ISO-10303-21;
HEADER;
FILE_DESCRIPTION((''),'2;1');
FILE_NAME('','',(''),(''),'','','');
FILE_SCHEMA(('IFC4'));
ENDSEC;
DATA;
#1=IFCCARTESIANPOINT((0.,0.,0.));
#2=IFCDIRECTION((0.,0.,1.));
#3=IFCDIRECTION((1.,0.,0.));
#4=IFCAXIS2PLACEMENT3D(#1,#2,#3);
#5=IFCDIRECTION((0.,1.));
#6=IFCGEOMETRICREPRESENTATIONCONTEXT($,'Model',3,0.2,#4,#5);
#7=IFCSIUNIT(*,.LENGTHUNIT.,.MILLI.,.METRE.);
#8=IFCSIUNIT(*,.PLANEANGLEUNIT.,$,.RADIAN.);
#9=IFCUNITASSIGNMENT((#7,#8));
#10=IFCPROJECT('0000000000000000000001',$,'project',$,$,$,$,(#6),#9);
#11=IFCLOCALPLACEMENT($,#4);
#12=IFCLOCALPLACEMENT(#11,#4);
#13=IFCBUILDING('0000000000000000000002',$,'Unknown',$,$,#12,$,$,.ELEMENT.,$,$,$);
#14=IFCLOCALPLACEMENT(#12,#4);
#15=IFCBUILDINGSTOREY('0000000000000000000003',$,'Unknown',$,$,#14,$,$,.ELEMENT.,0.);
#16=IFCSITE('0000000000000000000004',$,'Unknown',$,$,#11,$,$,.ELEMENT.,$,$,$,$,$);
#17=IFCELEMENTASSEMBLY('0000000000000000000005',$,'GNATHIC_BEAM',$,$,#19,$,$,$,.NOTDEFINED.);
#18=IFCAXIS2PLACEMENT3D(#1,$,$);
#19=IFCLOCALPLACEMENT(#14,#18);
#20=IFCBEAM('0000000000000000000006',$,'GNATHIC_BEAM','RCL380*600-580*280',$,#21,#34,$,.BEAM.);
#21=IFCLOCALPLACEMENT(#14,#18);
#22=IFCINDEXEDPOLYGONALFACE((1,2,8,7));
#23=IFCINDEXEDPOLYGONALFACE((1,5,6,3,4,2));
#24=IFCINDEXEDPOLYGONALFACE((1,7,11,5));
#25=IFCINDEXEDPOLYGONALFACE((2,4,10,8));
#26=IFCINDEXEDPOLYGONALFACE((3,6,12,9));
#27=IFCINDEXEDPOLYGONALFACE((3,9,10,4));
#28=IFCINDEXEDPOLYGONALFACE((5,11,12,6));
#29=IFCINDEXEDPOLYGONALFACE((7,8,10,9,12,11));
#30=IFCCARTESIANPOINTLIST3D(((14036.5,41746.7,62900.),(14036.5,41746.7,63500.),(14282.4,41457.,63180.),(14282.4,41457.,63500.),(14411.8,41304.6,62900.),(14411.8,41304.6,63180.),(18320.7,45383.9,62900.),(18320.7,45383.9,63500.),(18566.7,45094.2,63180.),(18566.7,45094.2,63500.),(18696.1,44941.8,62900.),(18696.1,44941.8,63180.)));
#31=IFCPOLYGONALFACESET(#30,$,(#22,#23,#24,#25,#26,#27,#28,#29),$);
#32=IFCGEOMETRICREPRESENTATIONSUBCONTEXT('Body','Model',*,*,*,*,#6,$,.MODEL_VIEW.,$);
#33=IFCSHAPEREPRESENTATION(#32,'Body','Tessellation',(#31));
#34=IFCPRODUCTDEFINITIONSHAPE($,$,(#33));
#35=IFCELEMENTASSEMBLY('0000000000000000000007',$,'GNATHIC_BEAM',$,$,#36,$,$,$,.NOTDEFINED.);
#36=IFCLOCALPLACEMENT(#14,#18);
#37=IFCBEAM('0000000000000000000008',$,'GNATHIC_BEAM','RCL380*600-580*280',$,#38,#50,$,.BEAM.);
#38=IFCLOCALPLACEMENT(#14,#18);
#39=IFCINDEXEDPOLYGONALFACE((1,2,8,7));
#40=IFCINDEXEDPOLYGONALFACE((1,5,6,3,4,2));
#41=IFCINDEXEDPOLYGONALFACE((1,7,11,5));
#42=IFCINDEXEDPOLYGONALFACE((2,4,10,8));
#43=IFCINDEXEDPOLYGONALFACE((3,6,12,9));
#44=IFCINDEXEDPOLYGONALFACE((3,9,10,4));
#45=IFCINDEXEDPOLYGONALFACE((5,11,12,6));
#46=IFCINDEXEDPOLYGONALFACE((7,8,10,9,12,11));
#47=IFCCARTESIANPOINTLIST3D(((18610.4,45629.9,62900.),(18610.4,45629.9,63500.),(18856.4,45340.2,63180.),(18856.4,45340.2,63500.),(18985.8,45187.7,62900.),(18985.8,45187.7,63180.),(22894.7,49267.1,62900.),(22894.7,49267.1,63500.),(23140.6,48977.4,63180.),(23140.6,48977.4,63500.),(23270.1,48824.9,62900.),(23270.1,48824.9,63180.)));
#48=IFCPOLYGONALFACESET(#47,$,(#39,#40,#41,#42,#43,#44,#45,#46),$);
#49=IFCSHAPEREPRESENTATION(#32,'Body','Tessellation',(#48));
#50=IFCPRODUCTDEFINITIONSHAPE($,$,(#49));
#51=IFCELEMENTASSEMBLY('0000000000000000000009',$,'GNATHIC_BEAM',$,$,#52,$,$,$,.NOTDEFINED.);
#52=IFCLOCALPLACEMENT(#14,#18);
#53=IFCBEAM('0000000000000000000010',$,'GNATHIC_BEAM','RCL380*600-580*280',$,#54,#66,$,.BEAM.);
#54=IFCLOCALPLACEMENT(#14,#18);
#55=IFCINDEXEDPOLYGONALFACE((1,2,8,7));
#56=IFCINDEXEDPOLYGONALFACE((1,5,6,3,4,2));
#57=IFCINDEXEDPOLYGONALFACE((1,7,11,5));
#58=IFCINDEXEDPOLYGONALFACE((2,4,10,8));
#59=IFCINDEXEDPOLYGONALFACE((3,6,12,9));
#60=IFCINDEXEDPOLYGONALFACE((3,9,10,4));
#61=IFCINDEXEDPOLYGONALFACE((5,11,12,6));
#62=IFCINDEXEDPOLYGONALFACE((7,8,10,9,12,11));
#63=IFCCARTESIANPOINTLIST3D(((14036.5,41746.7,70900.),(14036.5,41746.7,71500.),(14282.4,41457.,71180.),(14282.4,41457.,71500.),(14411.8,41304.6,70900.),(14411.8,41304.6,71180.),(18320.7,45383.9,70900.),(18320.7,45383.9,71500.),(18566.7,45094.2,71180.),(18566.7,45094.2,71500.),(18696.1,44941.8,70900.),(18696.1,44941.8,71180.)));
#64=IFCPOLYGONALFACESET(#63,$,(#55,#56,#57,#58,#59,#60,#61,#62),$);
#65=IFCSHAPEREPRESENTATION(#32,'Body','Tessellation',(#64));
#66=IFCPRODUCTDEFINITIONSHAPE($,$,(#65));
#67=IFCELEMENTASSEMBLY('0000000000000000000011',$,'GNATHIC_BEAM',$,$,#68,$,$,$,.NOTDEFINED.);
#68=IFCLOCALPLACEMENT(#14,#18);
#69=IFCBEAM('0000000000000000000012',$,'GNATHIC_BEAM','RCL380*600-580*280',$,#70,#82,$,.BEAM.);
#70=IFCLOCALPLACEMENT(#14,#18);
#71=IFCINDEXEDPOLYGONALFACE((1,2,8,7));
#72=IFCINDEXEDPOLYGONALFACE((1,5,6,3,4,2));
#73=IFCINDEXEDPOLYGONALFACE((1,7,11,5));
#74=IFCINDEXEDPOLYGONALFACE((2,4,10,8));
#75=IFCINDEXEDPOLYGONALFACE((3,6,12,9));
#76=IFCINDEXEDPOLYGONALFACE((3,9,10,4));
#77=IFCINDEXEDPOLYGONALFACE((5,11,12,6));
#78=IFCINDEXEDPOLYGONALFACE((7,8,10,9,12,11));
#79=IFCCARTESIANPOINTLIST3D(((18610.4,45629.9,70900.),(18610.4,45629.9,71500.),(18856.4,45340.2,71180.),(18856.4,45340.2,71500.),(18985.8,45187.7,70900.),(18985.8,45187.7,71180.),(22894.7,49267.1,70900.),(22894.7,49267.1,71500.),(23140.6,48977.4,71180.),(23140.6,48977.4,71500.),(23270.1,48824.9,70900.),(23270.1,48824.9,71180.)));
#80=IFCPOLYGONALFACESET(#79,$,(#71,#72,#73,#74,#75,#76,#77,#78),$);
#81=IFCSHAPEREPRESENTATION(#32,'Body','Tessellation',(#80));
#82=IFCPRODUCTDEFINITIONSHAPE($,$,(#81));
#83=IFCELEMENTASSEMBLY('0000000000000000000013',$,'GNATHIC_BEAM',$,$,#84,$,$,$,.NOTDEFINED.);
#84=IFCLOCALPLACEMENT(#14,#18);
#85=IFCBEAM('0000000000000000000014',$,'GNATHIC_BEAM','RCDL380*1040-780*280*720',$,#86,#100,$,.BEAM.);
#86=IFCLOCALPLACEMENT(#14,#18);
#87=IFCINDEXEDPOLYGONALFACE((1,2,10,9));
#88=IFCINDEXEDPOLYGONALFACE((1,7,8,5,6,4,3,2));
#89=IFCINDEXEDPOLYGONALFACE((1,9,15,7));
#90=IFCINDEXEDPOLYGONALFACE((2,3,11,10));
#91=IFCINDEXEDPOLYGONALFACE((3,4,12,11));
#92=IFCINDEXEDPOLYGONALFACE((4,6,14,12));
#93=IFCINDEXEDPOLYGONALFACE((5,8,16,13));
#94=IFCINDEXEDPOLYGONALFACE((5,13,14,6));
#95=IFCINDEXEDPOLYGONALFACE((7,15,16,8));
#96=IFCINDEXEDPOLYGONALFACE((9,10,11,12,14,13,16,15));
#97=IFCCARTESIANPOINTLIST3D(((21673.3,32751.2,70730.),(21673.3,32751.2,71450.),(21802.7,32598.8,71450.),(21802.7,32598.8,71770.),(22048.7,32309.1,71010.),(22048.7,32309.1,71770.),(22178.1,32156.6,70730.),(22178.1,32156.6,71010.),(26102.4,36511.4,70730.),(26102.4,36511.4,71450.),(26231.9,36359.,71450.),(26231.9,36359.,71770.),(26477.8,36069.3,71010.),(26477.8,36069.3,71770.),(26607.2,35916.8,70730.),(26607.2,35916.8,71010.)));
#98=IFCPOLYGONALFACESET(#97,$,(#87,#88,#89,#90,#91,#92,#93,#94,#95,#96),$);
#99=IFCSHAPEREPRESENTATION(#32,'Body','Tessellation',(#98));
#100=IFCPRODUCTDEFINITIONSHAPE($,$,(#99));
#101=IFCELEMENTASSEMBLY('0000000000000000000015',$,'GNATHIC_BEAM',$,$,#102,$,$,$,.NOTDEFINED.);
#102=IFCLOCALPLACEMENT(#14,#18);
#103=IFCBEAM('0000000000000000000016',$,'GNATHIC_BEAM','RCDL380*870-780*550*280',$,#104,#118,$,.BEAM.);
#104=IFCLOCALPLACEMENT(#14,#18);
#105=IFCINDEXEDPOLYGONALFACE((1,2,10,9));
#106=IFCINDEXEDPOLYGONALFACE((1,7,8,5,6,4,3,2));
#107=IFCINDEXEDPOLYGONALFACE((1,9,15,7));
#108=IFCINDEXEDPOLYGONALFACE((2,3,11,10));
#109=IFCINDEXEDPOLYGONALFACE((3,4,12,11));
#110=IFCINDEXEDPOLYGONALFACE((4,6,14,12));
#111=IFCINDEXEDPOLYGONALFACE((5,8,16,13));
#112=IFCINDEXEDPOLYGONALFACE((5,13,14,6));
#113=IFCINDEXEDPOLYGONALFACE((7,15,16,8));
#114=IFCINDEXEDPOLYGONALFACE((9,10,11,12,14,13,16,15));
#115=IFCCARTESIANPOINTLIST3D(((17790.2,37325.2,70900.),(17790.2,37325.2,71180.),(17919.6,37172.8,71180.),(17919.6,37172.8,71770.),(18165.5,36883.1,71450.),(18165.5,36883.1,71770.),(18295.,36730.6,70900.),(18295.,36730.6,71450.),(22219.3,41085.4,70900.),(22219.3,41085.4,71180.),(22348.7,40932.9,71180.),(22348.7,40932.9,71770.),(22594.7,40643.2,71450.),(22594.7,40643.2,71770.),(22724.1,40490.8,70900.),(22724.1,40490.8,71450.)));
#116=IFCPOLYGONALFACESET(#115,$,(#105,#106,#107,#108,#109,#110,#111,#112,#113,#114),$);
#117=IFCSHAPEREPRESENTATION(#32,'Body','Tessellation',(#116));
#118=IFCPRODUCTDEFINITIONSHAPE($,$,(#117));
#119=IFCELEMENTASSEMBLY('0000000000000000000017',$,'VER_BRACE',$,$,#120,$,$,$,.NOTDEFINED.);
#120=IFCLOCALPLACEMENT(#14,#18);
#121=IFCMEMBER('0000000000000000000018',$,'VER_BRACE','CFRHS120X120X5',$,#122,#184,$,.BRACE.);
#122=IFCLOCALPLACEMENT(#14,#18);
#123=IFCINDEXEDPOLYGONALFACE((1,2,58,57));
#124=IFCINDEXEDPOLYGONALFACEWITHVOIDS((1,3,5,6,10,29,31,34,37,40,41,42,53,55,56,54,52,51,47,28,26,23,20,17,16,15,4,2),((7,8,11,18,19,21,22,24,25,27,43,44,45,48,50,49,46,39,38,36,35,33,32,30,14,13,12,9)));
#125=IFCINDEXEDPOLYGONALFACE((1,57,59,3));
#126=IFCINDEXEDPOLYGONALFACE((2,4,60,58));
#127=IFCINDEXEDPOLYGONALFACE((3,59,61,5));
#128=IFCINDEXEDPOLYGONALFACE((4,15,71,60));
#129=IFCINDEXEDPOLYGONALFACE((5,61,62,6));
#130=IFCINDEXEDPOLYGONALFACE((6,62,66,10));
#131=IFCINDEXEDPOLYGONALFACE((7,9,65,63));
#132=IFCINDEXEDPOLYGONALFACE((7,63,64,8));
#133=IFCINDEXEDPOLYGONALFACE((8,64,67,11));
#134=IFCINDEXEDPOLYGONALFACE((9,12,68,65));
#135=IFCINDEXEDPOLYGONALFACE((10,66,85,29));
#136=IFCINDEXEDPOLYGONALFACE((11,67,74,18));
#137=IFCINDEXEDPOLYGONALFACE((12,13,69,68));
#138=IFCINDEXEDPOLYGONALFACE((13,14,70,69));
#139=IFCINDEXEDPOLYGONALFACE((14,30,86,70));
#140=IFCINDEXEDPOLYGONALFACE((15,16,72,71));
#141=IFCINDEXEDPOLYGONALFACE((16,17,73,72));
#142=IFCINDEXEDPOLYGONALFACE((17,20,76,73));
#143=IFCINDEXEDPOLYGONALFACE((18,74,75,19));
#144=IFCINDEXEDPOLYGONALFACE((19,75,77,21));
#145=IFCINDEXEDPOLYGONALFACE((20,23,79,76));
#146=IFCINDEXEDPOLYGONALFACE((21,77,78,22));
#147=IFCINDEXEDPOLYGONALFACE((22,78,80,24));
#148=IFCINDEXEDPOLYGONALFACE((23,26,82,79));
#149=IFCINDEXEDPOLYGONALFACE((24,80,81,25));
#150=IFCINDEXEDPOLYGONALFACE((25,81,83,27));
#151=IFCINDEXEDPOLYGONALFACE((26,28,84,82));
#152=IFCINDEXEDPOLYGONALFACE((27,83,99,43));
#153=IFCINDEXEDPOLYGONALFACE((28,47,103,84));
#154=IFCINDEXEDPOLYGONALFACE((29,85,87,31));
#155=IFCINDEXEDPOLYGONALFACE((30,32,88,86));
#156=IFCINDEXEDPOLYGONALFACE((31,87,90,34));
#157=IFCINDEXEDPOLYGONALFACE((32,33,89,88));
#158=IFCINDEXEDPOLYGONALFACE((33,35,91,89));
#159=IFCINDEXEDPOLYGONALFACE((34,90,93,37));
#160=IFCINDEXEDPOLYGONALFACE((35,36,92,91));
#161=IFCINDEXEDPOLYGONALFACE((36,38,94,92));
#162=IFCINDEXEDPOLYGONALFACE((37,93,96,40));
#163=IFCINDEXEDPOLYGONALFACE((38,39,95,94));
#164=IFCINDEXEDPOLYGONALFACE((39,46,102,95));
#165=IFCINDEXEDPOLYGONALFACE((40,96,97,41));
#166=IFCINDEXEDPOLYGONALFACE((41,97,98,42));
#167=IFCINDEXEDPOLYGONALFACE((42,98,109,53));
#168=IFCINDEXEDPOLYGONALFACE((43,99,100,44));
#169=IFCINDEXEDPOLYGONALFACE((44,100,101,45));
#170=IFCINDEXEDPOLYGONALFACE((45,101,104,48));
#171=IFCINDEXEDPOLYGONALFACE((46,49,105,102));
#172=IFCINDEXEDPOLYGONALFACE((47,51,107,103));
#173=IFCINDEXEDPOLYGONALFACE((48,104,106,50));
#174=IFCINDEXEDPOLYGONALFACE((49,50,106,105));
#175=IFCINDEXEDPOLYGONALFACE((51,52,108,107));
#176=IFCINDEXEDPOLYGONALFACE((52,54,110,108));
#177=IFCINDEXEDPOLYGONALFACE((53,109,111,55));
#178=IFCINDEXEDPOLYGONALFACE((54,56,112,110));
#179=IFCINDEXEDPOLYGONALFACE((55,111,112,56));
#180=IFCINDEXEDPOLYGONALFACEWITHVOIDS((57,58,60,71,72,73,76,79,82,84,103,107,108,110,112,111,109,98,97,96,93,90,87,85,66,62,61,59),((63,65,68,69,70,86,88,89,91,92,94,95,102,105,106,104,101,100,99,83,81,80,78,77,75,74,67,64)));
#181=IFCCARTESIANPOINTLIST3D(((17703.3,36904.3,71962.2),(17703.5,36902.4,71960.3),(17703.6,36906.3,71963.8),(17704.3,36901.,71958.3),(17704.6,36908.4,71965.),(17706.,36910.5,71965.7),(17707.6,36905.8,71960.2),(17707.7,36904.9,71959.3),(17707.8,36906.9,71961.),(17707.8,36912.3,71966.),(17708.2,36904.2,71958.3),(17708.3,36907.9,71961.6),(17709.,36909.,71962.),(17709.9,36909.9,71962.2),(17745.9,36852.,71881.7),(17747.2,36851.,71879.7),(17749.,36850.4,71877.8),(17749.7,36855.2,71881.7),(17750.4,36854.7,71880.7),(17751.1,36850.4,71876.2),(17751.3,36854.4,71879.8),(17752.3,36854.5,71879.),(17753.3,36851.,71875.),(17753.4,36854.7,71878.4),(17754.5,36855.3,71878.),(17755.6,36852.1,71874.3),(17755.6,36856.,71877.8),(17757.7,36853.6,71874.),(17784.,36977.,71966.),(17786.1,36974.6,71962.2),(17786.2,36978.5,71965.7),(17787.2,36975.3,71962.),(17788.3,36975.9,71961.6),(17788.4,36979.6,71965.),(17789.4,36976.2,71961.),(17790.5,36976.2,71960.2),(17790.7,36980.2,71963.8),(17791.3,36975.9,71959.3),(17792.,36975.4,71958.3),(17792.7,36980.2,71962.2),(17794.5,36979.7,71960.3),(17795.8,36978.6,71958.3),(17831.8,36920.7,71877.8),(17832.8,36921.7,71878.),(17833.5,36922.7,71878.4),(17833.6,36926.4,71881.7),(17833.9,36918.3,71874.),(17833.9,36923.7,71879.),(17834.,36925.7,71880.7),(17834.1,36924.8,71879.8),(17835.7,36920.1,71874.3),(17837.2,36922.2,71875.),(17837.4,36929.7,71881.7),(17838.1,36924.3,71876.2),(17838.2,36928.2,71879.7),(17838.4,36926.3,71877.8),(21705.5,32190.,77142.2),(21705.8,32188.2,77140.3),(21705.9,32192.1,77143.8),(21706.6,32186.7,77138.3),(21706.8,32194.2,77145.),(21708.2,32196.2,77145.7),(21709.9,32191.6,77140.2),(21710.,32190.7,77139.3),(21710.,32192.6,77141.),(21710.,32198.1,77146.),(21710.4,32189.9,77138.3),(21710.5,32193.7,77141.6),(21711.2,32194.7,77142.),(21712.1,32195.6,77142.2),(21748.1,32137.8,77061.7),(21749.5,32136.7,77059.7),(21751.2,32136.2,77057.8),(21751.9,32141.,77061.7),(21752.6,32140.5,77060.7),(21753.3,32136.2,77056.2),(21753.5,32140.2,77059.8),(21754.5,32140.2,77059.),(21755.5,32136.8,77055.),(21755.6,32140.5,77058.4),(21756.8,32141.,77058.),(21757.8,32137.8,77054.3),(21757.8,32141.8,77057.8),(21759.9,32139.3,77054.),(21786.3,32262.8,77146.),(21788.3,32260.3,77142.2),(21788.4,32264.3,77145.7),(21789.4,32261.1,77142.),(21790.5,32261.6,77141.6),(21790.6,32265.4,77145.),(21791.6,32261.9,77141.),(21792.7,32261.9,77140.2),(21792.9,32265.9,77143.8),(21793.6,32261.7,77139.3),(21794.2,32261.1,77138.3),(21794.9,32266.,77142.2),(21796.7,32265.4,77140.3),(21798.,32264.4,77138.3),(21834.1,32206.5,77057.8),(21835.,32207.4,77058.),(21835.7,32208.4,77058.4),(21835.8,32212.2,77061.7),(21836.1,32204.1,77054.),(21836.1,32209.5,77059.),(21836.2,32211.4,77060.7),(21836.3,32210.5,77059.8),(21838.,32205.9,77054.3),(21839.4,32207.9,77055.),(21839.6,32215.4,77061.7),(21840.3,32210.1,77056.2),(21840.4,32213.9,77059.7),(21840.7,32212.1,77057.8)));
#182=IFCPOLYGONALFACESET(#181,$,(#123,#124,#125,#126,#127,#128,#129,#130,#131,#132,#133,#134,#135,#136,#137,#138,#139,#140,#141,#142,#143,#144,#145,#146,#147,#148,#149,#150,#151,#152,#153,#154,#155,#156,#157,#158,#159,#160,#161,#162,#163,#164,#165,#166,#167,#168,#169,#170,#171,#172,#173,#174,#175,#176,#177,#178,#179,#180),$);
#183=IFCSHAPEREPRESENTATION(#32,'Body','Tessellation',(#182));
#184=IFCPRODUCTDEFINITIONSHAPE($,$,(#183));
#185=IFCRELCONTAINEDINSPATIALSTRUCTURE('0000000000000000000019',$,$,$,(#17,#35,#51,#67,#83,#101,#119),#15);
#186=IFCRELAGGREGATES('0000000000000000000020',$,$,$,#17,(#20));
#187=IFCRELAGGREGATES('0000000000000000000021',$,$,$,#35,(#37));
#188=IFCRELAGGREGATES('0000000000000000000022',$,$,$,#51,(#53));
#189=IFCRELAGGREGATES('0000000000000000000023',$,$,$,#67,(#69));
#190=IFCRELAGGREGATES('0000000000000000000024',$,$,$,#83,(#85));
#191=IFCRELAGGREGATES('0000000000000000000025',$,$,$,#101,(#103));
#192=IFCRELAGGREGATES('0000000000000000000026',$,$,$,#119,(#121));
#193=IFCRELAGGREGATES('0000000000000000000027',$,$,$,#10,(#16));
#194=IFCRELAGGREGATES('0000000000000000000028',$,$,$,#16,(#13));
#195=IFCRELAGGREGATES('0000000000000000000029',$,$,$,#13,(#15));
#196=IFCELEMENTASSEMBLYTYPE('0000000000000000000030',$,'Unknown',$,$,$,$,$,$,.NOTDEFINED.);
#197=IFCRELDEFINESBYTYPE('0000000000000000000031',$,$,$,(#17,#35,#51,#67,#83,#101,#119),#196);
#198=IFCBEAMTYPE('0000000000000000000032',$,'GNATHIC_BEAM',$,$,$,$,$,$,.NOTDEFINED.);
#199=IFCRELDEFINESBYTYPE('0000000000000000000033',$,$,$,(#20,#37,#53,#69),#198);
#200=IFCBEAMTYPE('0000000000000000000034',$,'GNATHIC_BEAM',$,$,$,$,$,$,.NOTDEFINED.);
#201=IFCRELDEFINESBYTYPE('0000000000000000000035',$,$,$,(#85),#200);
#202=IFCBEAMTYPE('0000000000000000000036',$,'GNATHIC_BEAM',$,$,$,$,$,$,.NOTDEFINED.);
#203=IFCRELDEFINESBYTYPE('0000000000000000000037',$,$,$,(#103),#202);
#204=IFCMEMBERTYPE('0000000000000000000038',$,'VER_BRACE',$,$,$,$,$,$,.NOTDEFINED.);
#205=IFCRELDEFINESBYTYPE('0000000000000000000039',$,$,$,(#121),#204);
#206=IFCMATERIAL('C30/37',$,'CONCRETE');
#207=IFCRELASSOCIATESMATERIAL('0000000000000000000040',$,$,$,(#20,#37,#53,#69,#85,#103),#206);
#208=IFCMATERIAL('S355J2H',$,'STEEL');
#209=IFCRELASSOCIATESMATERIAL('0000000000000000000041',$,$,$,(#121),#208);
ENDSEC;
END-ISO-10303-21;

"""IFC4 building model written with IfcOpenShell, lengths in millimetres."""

from ifc_helpers import new_model, si_unit, direction, frame, origin_with_axes, origin_2d_with_axis, place, context, subcontext, project, spatial, polyline, hollow_rectangle, outline, extrude, material, material_profile, profile_set, profile_usage, type_object, element, aggregate, save


model = new_model("IFC4")

# Units and contexts
model_context = context("Model", 3, precision=0.2, world=origin_with_axes(), true_north=direction((0.0, 1.0)))
body_context = subcontext(model_context, "Body", "Model", "MODEL_VIEW")
ifc_project = project(units=[si_unit("LENGTHUNIT", "METRE", prefix="MILLI"), si_unit("PLANEANGLEUNIT", "RADIAN")], contexts=[model_context])

# Site, building, storey
site_placement = place(None, origin_with_axes())
site = spatial("IfcSite", under=ifc_project, at=site_placement, Name="Unknown", CompositionType="ELEMENT")
building_placement = place(site_placement, origin_with_axes())
building = spatial("IfcBuilding", under=site, at=building_placement, Name="Unknown", CompositionType="ELEMENT")
storey_placement = place(building_placement, origin_with_axes())
storey = spatial("IfcBuildingStorey", under=building, at=storey_placement, Name="Unknown", CompositionType="ELEMENT", Elevation=0.0)

# Shared definitions
element_assembly_type = type_object("IfcElementAssemblyType", Name="Unknown", PredefinedType="NOTDEFINED")

# Element assemblies, beams
ifc_material_1 = material(Name="C30/37", Category="CONCRETE")
ifc_material_profile_1 = material_profile(ifc_material_1, outline(polyline([(-190.0, -300.0), (390.0, -300.0), (390.0, -20.0), (190.0, -20.0), (190.0, 300.0), (-190.0, 300.0), (-190.0, -300.0)])), Name="RCL380*600-580*280")
ifc_profile_set_1 = profile_set([ifc_material_profile_1])
ifc_profile_usage_1 = profile_usage(ifc_profile_set_1, cardinal=2)
beam_type_1 = type_object("IfcBeamType", Name="GNATHIC_BEAM")
assembly_1_placement = place(storey_placement, frame((14159.4, 41601.9, 63200.0), z_axis=(0.64719, -0.762329, 0.0), x_axis=(0.762329, 0.64719, 0.0)))
assembly_1 = element("IfcElementAssembly", 1, at=assembly_1_placement, inside=storey, type_object=element_assembly_type, Name="GNATHIC_BEAM", PredefinedType="NOTDEFINED")
beam_1_placement = place(assembly_1_placement, origin_with_axes())
beam_1 = element("IfcBeam", 2, at=beam_1_placement, type_object=beam_type_1, material=ifc_profile_usage_1, Name="GNATHIC_BEAM", Description="RCL380*600-580*280", PredefinedType="BEAM", context=body_context, shape_type="SolidModel", body=[
    extrude(outline(polyline([(-190.0, -300.0), (390.0, -300.0), (390.0, -20.0), (190.0, -20.0), (190.0, 300.0), (-190.0, 300.0), (-190.0, -300.0)])), frame((0.0, 0.0, 0.0), z_axis=(-1.0, 0.0, 0.0), x_axis=(0.0, 0.0, 1.0)), (0.0, 0.0, -1.0), 5620.0),
])
aggregate(assembly_1, [beam_1])
assembly_2_placement = place(storey_placement, frame((18733.4, 45485.0, 63200.0), z_axis=(0.64719, -0.762329, 0.0), x_axis=(0.762329, 0.64719, 0.0)))
assembly_2 = element("IfcElementAssembly", 3, at=assembly_2_placement, inside=storey, type_object=element_assembly_type, Name="GNATHIC_BEAM", PredefinedType="NOTDEFINED")
beam_2_placement = place(assembly_2_placement, origin_with_axes())
beam_2 = element("IfcBeam", 4, at=beam_2_placement, type_object=beam_type_1, material=ifc_profile_usage_1, Name="GNATHIC_BEAM", Description="RCL380*600-580*280", PredefinedType="BEAM", context=body_context, shape_type="SolidModel", body=[
    extrude(outline(polyline([(-190.0, -300.0), (390.0, -300.0), (390.0, -20.0), (190.0, -20.0), (190.0, 300.0), (-190.0, 300.0), (-190.0, -300.0)])), frame((0.0, 0.0, 0.0), z_axis=(-1.0, 0.0, 0.0), x_axis=(0.0, 0.0, 1.0)), (0.0, 0.0, -1.0), 5620.0),
])
aggregate(assembly_2, [beam_2])
assembly_3_placement = place(storey_placement, frame((14159.4, 41601.9, 71200.0), z_axis=(0.64719, -0.762329, 0.0), x_axis=(0.762329, 0.64719, 0.0)))
assembly_3 = element("IfcElementAssembly", 5, at=assembly_3_placement, inside=storey, type_object=element_assembly_type, Name="GNATHIC_BEAM", PredefinedType="NOTDEFINED")
beam_3_placement = place(assembly_3_placement, origin_with_axes())
beam_3 = element("IfcBeam", 6, at=beam_3_placement, type_object=beam_type_1, material=ifc_profile_usage_1, Name="GNATHIC_BEAM", Description="RCL380*600-580*280", PredefinedType="BEAM", context=body_context, shape_type="SolidModel", body=[
    extrude(outline(polyline([(-190.0, -300.0), (390.0, -300.0), (390.0, -20.0), (190.0, -20.0), (190.0, 300.0), (-190.0, 300.0), (-190.0, -300.0)])), frame((0.0, 0.0, 0.0), z_axis=(-1.0, 0.0, 0.0), x_axis=(0.0, 0.0, 1.0)), (0.0, 0.0, -1.0), 5620.0),
])
aggregate(assembly_3, [beam_3])
assembly_4_placement = place(storey_placement, frame((18733.4, 45485.0, 71200.0), z_axis=(0.64719, -0.762329, 0.0), x_axis=(0.762329, 0.64719, 0.0)))
assembly_4 = element("IfcElementAssembly", 7, at=assembly_4_placement, inside=storey, type_object=element_assembly_type, Name="GNATHIC_BEAM", PredefinedType="NOTDEFINED")
beam_4_placement = place(assembly_4_placement, origin_with_axes())
beam_4 = element("IfcBeam", 8, at=beam_4_placement, type_object=beam_type_1, material=ifc_profile_usage_1, Name="GNATHIC_BEAM", Description="RCL380*600-580*280", PredefinedType="BEAM", context=body_context, shape_type="SolidModel", body=[
    extrude(outline(polyline([(-190.0, -300.0), (390.0, -300.0), (390.0, -20.0), (190.0, -20.0), (190.0, 300.0), (-190.0, 300.0), (-190.0, -300.0)])), frame((0.0, 0.0, 0.0), z_axis=(-1.0, 0.0, 0.0), x_axis=(0.0, 0.0, 1.0)), (0.0, 0.0, -1.0), 5620.0),
])
aggregate(assembly_4, [beam_4])

# Element assemblies, beams
assembly_5_placement = place(storey_placement, frame((21925.7, 32453.9, 71250.0), z_axis=(0.64719, -0.762329, 0.0), x_axis=(0.762329, 0.64719, 0.0)))
assembly_5 = element("IfcElementAssembly", 9, at=assembly_5_placement, inside=storey, type_object=element_assembly_type, Name="GNATHIC_BEAM", PredefinedType="NOTDEFINED")
ifc_material_profile_2 = material_profile(ifc_material_1, outline(polyline([(-390.0, -520.0), (390.0, -520.0), (390.0, -240.0), (190.0, -240.0), (190.0, 520.0), (-190.0, 520.0), (-190.0, 200.0), (-390.0, 200.0), (-390.0, -520.0)])), Name="RCDL380*1040-780*280*720")
ifc_profile_set_2 = profile_set([ifc_material_profile_2])
ifc_profile_usage_2 = profile_usage(ifc_profile_set_2, cardinal=2)
beam_type_2 = type_object("IfcBeamType", Name="GNATHIC_BEAM")
beam_5_placement = place(assembly_5_placement, origin_with_axes())
beam_5 = element("IfcBeam", 10, at=beam_5_placement, type_object=beam_type_2, material=ifc_profile_usage_2, Name="GNATHIC_BEAM", Description="RCDL380*1040-780*280*720", PredefinedType="BEAM", context=body_context, shape_type="SolidModel", body=[
    extrude(outline(polyline([(-390.0, -520.0), (390.0, -520.0), (390.0, -240.0), (190.0, -240.0), (190.0, 520.0), (-190.0, 520.0), (-190.0, 200.0), (-390.0, 200.0), (-390.0, -520.0)])), frame((0.0, 0.0, 0.0), z_axis=(-1.0, 0.0, 0.0), x_axis=(0.0, 0.0, 1.0)), (0.0, 0.0, -1.0), 5810.0),
])
aggregate(assembly_5, [beam_5])
assembly_6_placement = place(storey_placement, frame((18042.6, 37027.9, 71335.0), z_axis=(0.64719, -0.762329, 0.0), x_axis=(0.762329, 0.64719, 0.0)))
assembly_6 = element("IfcElementAssembly", 11, at=assembly_6_placement, inside=storey, type_object=element_assembly_type, Name="GNATHIC_BEAM", PredefinedType="NOTDEFINED")
ifc_material_profile_3 = material_profile(ifc_material_1, outline(polyline([(-390.0, -435.0), (390.0, -435.0), (390.0, 115.0), (190.0, 115.0), (190.0, 435.0), (-190.0, 435.0), (-190.0, -155.0), (-390.0, -155.0), (-390.0, -435.0)])), Name="RCDL380*870-780*550*280")
ifc_profile_set_3 = profile_set([ifc_material_profile_3])
ifc_profile_usage_3 = profile_usage(ifc_profile_set_3, cardinal=2)
beam_type_3 = type_object("IfcBeamType", Name="GNATHIC_BEAM")
beam_6_placement = place(assembly_6_placement, origin_with_axes())
beam_6 = element("IfcBeam", 12, at=beam_6_placement, type_object=beam_type_3, material=ifc_profile_usage_3, Name="GNATHIC_BEAM", Description="RCDL380*870-780*550*280", PredefinedType="BEAM", context=body_context, shape_type="SolidModel", body=[
    extrude(outline(polyline([(-390.0, -435.0), (390.0, -435.0), (390.0, 115.0), (190.0, 115.0), (190.0, 435.0), (-190.0, 435.0), (-190.0, -155.0), (-390.0, -155.0), (-390.0, -435.0)])), frame((0.0, 0.0, 0.0), z_axis=(-1.0, 0.0, 0.0), x_axis=(0.0, 0.0, 1.0)), (0.0, 0.0, -1.0), 5810.0),
])
aggregate(assembly_6, [beam_6])

# Element assembly, member
assembly_7_placement = place(storey_placement, frame((17770.9, 36915.3, 71920.0), z_axis=(-0.762329, -0.64719, 0.0), x_axis=(0.496131, -0.584396, 0.642133)))
assembly_7 = element("IfcElementAssembly", 13, at=assembly_7_placement, inside=storey, type_object=element_assembly_type, Name="VER_BRACE", PredefinedType="NOTDEFINED")
ifc_material_2 = material(Name="S355J2H", Category="STEEL")
ifc_material_profile_4 = material_profile(ifc_material_2, hollow_rectangle(XDim=120.0, YDim=120.0, WallThickness=5.0, InnerFilletRadius=5.0, OuterFilletRadius=10.0, at=origin_2d_with_axis()), Name="CFRHS120X120X5")
ifc_profile_set_4 = profile_set([ifc_material_profile_4])
ifc_profile_usage_4 = profile_usage(ifc_profile_set_4, cardinal=5)
member_type = type_object("IfcMemberType", Name="VER_BRACE")
member_placement = place(assembly_7_placement, origin_with_axes())
member = element("IfcMember", 14, at=member_placement, type_object=member_type, material=ifc_profile_usage_4, Name="VER_BRACE", Description="CFRHS120X120X5", PredefinedType="BRACE", context=body_context, shape_type="SolidModel", body=[
    extrude(hollow_rectangle(XDim=120.0, YDim=120.0, WallThickness=5.0, InnerFilletRadius=5.0, OuterFilletRadius=10.0, at=origin_2d_with_axis()), frame((0.0, 0.0, 0.0), z_axis=(-1.0, 0.0, 0.0), x_axis=(0.0, 0.0, 1.0)), (0.0, 0.0, -1.0), 8066.9),
])
aggregate(assembly_7, [member])

save(model, "model.ifc")
